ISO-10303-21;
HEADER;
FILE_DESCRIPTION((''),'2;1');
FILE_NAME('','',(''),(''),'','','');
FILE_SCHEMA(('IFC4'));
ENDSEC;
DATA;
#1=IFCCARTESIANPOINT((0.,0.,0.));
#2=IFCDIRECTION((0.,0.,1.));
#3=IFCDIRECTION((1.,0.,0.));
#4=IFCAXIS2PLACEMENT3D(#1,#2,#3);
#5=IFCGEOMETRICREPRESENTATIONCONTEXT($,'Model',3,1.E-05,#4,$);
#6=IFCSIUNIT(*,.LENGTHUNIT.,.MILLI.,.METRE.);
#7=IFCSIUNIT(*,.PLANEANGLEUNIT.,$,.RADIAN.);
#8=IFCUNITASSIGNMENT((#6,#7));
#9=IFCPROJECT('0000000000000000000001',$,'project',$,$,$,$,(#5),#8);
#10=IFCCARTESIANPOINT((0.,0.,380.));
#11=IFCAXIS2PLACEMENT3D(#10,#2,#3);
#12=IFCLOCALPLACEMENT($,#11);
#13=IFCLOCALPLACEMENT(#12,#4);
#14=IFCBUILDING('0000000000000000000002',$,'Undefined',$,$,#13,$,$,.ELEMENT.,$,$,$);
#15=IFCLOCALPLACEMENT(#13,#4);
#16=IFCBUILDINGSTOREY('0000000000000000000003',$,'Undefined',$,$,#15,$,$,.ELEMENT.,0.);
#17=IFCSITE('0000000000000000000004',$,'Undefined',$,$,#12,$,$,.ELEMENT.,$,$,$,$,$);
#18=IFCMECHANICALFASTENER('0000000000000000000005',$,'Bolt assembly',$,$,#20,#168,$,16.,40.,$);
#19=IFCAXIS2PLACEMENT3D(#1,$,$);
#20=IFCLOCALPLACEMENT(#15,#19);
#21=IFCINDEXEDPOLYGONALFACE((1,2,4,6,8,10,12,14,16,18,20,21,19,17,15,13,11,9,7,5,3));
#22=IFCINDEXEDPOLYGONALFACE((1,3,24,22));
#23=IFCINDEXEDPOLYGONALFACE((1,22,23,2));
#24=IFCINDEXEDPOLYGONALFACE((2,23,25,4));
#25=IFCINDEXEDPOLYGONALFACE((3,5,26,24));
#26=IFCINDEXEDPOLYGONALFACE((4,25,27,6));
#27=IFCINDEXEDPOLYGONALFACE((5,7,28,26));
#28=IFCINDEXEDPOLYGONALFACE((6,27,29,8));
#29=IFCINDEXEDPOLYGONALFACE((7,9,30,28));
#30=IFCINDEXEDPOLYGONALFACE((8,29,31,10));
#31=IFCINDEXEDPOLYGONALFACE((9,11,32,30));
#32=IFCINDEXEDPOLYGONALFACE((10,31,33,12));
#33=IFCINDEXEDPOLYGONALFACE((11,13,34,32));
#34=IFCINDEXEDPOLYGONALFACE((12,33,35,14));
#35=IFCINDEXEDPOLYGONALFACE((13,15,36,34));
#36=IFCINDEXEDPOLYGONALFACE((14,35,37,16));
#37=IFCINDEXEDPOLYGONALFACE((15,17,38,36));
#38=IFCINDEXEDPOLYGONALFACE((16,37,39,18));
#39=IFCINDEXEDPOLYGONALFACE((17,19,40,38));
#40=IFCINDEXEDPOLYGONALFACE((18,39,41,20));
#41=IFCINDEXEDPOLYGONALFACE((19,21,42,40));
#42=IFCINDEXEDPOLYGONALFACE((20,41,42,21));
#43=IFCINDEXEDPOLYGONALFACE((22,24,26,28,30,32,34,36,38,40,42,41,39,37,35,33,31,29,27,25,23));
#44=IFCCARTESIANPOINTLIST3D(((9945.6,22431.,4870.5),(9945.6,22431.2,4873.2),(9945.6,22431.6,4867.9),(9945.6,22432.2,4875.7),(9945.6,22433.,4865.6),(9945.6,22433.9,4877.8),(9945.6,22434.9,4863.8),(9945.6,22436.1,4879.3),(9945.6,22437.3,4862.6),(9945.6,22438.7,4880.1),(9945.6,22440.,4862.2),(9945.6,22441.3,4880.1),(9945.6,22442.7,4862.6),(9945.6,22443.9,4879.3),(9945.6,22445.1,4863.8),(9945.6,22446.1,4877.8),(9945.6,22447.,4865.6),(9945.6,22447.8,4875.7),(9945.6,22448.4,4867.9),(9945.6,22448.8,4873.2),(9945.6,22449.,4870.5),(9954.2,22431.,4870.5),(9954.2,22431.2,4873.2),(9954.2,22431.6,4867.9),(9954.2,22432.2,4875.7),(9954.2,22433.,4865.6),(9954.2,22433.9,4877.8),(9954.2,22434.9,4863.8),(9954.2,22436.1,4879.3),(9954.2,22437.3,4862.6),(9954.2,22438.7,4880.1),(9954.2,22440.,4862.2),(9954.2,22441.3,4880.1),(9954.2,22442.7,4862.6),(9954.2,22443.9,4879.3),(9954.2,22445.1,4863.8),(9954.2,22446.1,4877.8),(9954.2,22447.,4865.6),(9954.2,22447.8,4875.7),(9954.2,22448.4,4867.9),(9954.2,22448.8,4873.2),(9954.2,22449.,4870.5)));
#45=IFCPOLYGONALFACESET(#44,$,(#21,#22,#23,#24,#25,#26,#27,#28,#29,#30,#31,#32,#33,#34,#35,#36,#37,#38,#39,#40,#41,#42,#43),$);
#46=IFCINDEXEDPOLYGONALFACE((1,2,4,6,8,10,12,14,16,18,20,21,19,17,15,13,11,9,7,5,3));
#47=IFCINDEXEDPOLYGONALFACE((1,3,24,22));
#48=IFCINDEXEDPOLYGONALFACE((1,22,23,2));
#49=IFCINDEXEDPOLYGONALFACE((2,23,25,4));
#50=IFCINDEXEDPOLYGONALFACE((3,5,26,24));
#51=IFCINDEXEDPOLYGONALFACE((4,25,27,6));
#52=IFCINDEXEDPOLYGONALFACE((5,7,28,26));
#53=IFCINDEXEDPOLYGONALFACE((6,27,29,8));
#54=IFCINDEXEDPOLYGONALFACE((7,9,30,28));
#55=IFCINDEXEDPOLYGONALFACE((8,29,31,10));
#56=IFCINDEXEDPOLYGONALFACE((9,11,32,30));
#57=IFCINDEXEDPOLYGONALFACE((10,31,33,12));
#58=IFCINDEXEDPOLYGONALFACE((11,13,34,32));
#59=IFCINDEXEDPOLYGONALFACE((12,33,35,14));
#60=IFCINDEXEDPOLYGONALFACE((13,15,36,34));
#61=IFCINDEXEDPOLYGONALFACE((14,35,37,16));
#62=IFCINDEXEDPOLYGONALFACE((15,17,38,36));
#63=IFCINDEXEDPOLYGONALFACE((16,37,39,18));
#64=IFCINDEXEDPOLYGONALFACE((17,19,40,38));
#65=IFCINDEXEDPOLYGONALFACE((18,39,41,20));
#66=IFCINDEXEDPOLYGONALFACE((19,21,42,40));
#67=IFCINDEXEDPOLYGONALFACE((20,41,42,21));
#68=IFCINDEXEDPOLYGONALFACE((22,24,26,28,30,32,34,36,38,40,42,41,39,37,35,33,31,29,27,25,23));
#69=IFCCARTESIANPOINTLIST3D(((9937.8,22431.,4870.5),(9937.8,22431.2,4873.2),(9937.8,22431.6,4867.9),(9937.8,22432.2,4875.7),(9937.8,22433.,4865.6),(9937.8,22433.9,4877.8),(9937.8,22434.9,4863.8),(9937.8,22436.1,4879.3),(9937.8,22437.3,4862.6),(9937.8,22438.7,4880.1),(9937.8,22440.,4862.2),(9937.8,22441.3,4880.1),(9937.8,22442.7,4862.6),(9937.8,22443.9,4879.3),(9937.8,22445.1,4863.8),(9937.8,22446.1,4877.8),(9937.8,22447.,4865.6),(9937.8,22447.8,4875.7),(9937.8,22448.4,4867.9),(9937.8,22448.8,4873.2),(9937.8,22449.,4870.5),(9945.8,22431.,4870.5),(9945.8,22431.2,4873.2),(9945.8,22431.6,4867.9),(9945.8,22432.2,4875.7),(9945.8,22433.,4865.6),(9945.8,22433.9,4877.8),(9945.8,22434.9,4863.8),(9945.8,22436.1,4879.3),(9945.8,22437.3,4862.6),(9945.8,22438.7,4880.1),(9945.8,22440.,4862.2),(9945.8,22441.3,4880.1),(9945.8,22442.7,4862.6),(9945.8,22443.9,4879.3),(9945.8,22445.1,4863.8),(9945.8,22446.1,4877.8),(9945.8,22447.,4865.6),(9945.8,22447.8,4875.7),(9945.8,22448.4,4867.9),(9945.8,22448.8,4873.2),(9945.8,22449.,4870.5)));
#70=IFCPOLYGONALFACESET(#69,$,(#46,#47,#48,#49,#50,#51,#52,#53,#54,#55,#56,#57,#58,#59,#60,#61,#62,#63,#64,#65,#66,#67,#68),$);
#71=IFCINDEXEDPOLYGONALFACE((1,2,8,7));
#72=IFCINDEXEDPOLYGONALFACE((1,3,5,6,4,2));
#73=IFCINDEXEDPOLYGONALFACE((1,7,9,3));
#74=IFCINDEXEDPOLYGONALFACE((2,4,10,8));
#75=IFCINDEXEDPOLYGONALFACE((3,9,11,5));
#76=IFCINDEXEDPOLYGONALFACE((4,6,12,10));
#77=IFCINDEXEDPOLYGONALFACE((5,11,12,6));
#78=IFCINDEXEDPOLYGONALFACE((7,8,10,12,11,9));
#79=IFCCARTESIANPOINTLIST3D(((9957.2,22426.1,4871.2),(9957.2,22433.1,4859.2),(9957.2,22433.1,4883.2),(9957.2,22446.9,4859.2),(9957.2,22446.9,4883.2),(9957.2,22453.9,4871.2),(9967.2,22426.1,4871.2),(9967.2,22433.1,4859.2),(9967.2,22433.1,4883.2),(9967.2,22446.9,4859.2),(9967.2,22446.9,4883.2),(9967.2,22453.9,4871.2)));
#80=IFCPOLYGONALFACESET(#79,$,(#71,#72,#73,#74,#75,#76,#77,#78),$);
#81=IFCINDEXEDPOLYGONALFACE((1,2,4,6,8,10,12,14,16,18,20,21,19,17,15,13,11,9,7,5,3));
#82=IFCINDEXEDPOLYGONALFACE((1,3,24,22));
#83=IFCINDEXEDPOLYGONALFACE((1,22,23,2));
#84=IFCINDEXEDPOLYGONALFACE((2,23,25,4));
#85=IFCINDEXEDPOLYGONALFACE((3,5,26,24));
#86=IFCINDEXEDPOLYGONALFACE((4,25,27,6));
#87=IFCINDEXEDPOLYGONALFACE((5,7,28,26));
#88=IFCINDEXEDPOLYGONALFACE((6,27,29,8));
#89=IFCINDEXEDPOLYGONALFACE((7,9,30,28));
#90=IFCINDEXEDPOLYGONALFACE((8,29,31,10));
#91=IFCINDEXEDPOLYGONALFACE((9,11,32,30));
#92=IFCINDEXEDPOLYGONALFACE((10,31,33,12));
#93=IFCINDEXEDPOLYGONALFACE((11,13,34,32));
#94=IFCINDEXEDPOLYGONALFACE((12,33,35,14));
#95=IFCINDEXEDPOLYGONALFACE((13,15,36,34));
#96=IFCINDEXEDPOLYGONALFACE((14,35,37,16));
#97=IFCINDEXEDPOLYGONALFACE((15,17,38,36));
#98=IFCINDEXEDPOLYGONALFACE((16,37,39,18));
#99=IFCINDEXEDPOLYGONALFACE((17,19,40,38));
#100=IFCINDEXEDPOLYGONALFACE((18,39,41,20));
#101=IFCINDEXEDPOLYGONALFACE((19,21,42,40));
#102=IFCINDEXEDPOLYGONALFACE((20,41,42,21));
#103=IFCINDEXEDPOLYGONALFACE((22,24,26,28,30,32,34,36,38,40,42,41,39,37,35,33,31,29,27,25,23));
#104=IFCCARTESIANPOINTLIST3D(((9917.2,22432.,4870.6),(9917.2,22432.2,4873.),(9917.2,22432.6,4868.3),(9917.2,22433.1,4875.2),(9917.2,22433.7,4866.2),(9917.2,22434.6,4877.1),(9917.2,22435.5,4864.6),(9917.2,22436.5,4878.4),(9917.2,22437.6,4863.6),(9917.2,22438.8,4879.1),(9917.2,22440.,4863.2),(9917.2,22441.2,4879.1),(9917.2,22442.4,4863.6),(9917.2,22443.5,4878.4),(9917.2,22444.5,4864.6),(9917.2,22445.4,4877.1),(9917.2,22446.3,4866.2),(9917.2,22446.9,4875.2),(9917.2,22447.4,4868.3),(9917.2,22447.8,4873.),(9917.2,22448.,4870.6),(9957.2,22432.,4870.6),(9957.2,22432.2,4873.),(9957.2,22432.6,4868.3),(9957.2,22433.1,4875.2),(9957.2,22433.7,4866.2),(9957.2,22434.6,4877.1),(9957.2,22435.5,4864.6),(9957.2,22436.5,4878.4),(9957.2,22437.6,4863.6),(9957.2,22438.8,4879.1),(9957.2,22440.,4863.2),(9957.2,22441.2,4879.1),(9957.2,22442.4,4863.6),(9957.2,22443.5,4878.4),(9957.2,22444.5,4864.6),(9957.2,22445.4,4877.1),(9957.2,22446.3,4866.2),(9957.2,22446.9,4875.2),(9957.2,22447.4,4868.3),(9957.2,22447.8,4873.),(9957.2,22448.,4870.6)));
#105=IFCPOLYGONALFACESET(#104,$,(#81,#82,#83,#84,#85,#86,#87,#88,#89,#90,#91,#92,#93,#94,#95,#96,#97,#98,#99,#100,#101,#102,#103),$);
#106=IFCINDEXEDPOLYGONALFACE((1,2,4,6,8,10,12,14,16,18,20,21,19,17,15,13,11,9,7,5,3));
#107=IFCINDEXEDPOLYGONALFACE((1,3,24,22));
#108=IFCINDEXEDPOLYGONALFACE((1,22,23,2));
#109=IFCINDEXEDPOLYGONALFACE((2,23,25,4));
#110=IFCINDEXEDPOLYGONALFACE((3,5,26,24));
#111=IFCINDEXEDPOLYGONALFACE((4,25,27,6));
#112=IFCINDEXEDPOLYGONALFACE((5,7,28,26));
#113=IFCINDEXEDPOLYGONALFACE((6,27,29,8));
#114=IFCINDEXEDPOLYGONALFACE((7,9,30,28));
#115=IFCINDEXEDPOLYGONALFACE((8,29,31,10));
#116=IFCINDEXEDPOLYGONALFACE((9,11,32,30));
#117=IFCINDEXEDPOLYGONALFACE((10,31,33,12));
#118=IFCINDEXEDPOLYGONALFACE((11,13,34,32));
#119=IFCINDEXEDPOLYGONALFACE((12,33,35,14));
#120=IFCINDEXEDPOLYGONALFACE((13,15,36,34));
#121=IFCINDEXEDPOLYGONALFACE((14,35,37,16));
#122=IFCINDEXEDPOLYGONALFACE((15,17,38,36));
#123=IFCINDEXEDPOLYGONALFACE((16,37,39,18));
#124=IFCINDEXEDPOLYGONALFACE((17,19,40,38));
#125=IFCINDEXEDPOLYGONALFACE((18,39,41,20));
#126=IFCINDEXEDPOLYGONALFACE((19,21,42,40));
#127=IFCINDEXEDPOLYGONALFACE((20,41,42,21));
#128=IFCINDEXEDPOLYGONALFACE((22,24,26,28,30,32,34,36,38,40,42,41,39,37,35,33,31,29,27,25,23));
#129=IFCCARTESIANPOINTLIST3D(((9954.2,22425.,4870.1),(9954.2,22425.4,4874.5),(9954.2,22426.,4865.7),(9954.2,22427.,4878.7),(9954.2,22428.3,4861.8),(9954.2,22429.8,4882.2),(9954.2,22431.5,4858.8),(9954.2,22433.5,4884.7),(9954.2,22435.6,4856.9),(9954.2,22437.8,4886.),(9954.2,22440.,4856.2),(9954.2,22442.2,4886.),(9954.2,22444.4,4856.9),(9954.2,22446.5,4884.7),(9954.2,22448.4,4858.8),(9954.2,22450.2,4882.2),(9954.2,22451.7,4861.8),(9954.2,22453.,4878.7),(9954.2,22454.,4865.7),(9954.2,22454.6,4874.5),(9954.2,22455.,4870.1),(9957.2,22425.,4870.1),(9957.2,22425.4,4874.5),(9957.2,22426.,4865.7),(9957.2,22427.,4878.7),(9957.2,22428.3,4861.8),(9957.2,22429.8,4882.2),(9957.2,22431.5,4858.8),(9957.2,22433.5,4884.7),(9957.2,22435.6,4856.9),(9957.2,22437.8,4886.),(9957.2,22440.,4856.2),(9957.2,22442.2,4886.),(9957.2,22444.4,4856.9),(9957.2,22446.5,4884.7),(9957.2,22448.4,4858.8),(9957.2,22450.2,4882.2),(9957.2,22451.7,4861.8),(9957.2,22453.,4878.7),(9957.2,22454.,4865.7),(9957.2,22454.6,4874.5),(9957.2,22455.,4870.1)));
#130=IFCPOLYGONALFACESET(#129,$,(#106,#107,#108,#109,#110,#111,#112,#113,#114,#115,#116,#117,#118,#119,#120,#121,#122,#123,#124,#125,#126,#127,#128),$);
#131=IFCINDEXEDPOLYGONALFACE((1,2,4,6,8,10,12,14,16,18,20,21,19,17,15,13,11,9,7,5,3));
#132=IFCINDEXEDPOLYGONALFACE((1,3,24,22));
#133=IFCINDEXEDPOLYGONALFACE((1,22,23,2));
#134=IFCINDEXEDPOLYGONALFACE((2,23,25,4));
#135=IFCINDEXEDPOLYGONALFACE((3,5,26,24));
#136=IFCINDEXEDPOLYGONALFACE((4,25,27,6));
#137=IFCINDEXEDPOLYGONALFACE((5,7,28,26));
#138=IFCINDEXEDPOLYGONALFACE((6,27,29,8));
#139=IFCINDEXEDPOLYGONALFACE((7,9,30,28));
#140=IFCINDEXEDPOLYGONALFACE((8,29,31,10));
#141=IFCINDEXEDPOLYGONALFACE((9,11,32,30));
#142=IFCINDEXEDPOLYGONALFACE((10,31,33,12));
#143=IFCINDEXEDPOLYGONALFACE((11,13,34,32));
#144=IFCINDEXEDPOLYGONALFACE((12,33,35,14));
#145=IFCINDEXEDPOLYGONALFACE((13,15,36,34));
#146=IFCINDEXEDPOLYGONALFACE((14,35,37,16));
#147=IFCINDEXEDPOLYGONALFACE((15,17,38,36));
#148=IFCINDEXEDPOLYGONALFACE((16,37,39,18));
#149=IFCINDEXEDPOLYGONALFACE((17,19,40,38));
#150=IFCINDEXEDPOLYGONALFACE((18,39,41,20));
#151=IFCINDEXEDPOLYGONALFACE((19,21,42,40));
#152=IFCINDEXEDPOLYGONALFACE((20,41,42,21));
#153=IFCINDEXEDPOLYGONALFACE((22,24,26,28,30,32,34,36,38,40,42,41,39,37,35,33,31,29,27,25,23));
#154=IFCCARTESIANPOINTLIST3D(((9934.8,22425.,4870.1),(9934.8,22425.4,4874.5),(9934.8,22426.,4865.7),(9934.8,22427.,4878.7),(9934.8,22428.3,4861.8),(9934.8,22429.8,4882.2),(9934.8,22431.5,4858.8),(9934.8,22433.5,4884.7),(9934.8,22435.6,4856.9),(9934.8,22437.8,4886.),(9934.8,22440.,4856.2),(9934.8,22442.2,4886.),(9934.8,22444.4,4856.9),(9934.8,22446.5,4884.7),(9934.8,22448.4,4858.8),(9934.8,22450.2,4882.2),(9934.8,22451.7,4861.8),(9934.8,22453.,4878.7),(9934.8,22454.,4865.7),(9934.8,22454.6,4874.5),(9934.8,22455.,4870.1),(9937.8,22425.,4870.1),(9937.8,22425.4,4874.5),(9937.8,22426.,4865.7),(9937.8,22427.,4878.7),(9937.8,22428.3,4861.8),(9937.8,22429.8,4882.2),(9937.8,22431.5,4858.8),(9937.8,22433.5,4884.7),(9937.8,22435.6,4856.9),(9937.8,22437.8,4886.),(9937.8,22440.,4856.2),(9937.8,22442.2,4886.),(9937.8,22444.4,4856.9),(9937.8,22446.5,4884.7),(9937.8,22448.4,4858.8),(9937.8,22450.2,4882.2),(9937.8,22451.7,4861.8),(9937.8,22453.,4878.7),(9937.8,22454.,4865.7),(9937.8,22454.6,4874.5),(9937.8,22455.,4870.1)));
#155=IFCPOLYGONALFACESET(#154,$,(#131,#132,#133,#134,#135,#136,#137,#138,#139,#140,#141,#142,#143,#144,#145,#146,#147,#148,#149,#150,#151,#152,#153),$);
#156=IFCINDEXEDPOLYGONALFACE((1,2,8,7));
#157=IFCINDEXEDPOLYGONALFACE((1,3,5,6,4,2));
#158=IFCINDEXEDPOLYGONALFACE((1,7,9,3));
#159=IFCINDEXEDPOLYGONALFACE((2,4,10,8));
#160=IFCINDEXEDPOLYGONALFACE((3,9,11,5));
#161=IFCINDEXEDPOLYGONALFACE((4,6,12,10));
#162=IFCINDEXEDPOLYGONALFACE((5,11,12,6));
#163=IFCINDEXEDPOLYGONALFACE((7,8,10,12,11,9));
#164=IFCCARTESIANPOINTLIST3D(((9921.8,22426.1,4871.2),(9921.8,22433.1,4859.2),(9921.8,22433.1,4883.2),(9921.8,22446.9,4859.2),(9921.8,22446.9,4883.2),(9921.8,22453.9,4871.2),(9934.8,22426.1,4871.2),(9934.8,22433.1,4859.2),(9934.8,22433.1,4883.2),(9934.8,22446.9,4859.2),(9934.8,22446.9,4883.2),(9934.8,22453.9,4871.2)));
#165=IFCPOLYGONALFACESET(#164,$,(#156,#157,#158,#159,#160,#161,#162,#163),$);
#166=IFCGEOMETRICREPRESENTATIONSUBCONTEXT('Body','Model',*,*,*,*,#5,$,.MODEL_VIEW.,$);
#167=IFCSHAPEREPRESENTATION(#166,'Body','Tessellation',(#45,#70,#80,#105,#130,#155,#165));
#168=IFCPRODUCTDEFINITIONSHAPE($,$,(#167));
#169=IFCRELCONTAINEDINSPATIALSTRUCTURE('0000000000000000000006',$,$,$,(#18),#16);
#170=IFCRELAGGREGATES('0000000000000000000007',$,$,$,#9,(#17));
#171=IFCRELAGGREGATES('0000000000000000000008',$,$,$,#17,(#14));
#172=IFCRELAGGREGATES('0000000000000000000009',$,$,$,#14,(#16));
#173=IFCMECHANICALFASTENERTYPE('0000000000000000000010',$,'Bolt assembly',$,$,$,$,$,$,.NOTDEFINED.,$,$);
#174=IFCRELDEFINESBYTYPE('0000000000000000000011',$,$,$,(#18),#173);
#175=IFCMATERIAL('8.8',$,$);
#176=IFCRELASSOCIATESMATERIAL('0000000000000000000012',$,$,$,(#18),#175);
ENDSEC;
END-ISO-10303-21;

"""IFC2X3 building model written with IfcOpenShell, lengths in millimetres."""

from ifc_helpers import new_model, si_unit, frame, origin_with_axes, origin_2d_with_axis, place, context, subcontext, project, spatial, polyline, circle, outline, extrude, source, transform, mapped, material, type_object, element, save


model = new_model("IFC2X3")

# Units and contexts
model_context = context("Model", 3, precision=1e-05, world=origin_with_axes())
body_context = subcontext(model_context, "Body", "Model", "MODEL_VIEW")
ifc_project = project(units=[si_unit("LENGTHUNIT", "METRE", prefix="MILLI"), si_unit("PLANEANGLEUNIT", "RADIAN")], contexts=[model_context])

# Site, building, storey
site_placement = place(None, frame((0.0, 0.0, 380.0), z_axis=(0.0, 0.0, 1.0), x_axis=(1.0, 0.0, 0.0)))
site = spatial("IfcSite", under=ifc_project, at=site_placement, Name="Undefined", CompositionType="ELEMENT")
building_placement = place(site_placement, origin_with_axes())
building = spatial("IfcBuilding", under=site, at=building_placement, Name="Undefined", CompositionType="ELEMENT")
storey_placement = place(building_placement, origin_with_axes())
storey = spatial("IfcBuildingStorey", under=building, at=storey_placement, Name="Undefined", CompositionType="ELEMENT", Elevation=0.0)

# Mechanical fastener
ifc_material_1 = material(Name="8.8")
mechanical_fastener_type = type_object("IfcMechanicalFastenerType", Name="Bolt assembly")
shared_shape_1 = source(origin_with_axes(), body_context, "Body", "SweptSolid", [
    extrude(circle(Radius=9.0, at=origin_2d_with_axis()), frame((0.0, -8.4, 0.0), z_axis=(0.0, 1.0, 0.0), x_axis=(1.0, 0.0, 0.0)), (0.0, 0.0, 1.0), 8.5),
    extrude(circle(Radius=9.0, at=origin_2d_with_axis()), frame((0.0, -0.1, 0.0), z_axis=(0.0, 1.0, 0.0), x_axis=(1.0, 0.0, 0.0)), (0.0, 0.0, 1.0), 8.1),
    extrude(outline(polyline([(12.0, -6.9), (12.0, 6.9), (0.0, 13.9), (-12.0, 6.9), (-12.0, -6.9), (0.0, -13.9), (12.0, -6.9)])), frame((0.0, -21.5, 0.0), z_axis=(0.0, 1.0, 0.0), x_axis=(1.0, 0.0, 0.0)), (0.0, 0.0, 1.0), 10.0),
    extrude(circle(Radius=8.0, at=origin_2d_with_axis()), frame((0.0, -11.5, 0.0), z_axis=(0.0, 1.0, 0.0), x_axis=(1.0, 0.0, 0.0)), (0.0, 0.0, 1.0), 40.0),
    extrude(circle(Radius=15.0, at=origin_2d_with_axis()), frame((0.0, -11.5, 0.0), z_axis=(0.0, 1.0, 0.0), x_axis=(1.0, 0.0, 0.0)), (0.0, 0.0, 1.0), 3.0),
    extrude(circle(Radius=15.0, at=origin_2d_with_axis()), frame((0.0, 8.0, 0.0), z_axis=(0.0, 1.0, 0.0), x_axis=(1.0, 0.0, 0.0)), (0.0, 0.0, 1.0), 3.0),
    extrude(outline(polyline([(12.0, -6.9), (12.0, 6.9), (0.0, 13.9), (-12.0, 6.9), (-12.0, -6.9), (0.0, -13.9), (12.0, -6.9)])), frame((0.0, 11.0, 0.0), z_axis=(0.0, 1.0, 0.0), x_axis=(1.0, 0.0, 0.0)), (0.0, 0.0, 1.0), 13.0),
])
for number, where, z_axis, x_axis, name in (
    (1, (9945.8, 22402.5, 4951.2), (0.0, 1.0, 0.0), (0.0, 0.0, -1.0), "Bolt assembly"),
):
    element("IfcMechanicalFastener", number, at=place(storey_placement, frame(where, z_axis=z_axis, x_axis=x_axis)), inside=storey, type_object=mechanical_fastener_type, material=ifc_material_1, Name=name, NominalDiameter=16.0, NominalLength=40.0, context=body_context, shape_type="MappedRepresentation", body=[
        mapped(shared_shape_1, transform((80.0, 0.0, 37.5))),
    ])

save(model, "model.ifc")
